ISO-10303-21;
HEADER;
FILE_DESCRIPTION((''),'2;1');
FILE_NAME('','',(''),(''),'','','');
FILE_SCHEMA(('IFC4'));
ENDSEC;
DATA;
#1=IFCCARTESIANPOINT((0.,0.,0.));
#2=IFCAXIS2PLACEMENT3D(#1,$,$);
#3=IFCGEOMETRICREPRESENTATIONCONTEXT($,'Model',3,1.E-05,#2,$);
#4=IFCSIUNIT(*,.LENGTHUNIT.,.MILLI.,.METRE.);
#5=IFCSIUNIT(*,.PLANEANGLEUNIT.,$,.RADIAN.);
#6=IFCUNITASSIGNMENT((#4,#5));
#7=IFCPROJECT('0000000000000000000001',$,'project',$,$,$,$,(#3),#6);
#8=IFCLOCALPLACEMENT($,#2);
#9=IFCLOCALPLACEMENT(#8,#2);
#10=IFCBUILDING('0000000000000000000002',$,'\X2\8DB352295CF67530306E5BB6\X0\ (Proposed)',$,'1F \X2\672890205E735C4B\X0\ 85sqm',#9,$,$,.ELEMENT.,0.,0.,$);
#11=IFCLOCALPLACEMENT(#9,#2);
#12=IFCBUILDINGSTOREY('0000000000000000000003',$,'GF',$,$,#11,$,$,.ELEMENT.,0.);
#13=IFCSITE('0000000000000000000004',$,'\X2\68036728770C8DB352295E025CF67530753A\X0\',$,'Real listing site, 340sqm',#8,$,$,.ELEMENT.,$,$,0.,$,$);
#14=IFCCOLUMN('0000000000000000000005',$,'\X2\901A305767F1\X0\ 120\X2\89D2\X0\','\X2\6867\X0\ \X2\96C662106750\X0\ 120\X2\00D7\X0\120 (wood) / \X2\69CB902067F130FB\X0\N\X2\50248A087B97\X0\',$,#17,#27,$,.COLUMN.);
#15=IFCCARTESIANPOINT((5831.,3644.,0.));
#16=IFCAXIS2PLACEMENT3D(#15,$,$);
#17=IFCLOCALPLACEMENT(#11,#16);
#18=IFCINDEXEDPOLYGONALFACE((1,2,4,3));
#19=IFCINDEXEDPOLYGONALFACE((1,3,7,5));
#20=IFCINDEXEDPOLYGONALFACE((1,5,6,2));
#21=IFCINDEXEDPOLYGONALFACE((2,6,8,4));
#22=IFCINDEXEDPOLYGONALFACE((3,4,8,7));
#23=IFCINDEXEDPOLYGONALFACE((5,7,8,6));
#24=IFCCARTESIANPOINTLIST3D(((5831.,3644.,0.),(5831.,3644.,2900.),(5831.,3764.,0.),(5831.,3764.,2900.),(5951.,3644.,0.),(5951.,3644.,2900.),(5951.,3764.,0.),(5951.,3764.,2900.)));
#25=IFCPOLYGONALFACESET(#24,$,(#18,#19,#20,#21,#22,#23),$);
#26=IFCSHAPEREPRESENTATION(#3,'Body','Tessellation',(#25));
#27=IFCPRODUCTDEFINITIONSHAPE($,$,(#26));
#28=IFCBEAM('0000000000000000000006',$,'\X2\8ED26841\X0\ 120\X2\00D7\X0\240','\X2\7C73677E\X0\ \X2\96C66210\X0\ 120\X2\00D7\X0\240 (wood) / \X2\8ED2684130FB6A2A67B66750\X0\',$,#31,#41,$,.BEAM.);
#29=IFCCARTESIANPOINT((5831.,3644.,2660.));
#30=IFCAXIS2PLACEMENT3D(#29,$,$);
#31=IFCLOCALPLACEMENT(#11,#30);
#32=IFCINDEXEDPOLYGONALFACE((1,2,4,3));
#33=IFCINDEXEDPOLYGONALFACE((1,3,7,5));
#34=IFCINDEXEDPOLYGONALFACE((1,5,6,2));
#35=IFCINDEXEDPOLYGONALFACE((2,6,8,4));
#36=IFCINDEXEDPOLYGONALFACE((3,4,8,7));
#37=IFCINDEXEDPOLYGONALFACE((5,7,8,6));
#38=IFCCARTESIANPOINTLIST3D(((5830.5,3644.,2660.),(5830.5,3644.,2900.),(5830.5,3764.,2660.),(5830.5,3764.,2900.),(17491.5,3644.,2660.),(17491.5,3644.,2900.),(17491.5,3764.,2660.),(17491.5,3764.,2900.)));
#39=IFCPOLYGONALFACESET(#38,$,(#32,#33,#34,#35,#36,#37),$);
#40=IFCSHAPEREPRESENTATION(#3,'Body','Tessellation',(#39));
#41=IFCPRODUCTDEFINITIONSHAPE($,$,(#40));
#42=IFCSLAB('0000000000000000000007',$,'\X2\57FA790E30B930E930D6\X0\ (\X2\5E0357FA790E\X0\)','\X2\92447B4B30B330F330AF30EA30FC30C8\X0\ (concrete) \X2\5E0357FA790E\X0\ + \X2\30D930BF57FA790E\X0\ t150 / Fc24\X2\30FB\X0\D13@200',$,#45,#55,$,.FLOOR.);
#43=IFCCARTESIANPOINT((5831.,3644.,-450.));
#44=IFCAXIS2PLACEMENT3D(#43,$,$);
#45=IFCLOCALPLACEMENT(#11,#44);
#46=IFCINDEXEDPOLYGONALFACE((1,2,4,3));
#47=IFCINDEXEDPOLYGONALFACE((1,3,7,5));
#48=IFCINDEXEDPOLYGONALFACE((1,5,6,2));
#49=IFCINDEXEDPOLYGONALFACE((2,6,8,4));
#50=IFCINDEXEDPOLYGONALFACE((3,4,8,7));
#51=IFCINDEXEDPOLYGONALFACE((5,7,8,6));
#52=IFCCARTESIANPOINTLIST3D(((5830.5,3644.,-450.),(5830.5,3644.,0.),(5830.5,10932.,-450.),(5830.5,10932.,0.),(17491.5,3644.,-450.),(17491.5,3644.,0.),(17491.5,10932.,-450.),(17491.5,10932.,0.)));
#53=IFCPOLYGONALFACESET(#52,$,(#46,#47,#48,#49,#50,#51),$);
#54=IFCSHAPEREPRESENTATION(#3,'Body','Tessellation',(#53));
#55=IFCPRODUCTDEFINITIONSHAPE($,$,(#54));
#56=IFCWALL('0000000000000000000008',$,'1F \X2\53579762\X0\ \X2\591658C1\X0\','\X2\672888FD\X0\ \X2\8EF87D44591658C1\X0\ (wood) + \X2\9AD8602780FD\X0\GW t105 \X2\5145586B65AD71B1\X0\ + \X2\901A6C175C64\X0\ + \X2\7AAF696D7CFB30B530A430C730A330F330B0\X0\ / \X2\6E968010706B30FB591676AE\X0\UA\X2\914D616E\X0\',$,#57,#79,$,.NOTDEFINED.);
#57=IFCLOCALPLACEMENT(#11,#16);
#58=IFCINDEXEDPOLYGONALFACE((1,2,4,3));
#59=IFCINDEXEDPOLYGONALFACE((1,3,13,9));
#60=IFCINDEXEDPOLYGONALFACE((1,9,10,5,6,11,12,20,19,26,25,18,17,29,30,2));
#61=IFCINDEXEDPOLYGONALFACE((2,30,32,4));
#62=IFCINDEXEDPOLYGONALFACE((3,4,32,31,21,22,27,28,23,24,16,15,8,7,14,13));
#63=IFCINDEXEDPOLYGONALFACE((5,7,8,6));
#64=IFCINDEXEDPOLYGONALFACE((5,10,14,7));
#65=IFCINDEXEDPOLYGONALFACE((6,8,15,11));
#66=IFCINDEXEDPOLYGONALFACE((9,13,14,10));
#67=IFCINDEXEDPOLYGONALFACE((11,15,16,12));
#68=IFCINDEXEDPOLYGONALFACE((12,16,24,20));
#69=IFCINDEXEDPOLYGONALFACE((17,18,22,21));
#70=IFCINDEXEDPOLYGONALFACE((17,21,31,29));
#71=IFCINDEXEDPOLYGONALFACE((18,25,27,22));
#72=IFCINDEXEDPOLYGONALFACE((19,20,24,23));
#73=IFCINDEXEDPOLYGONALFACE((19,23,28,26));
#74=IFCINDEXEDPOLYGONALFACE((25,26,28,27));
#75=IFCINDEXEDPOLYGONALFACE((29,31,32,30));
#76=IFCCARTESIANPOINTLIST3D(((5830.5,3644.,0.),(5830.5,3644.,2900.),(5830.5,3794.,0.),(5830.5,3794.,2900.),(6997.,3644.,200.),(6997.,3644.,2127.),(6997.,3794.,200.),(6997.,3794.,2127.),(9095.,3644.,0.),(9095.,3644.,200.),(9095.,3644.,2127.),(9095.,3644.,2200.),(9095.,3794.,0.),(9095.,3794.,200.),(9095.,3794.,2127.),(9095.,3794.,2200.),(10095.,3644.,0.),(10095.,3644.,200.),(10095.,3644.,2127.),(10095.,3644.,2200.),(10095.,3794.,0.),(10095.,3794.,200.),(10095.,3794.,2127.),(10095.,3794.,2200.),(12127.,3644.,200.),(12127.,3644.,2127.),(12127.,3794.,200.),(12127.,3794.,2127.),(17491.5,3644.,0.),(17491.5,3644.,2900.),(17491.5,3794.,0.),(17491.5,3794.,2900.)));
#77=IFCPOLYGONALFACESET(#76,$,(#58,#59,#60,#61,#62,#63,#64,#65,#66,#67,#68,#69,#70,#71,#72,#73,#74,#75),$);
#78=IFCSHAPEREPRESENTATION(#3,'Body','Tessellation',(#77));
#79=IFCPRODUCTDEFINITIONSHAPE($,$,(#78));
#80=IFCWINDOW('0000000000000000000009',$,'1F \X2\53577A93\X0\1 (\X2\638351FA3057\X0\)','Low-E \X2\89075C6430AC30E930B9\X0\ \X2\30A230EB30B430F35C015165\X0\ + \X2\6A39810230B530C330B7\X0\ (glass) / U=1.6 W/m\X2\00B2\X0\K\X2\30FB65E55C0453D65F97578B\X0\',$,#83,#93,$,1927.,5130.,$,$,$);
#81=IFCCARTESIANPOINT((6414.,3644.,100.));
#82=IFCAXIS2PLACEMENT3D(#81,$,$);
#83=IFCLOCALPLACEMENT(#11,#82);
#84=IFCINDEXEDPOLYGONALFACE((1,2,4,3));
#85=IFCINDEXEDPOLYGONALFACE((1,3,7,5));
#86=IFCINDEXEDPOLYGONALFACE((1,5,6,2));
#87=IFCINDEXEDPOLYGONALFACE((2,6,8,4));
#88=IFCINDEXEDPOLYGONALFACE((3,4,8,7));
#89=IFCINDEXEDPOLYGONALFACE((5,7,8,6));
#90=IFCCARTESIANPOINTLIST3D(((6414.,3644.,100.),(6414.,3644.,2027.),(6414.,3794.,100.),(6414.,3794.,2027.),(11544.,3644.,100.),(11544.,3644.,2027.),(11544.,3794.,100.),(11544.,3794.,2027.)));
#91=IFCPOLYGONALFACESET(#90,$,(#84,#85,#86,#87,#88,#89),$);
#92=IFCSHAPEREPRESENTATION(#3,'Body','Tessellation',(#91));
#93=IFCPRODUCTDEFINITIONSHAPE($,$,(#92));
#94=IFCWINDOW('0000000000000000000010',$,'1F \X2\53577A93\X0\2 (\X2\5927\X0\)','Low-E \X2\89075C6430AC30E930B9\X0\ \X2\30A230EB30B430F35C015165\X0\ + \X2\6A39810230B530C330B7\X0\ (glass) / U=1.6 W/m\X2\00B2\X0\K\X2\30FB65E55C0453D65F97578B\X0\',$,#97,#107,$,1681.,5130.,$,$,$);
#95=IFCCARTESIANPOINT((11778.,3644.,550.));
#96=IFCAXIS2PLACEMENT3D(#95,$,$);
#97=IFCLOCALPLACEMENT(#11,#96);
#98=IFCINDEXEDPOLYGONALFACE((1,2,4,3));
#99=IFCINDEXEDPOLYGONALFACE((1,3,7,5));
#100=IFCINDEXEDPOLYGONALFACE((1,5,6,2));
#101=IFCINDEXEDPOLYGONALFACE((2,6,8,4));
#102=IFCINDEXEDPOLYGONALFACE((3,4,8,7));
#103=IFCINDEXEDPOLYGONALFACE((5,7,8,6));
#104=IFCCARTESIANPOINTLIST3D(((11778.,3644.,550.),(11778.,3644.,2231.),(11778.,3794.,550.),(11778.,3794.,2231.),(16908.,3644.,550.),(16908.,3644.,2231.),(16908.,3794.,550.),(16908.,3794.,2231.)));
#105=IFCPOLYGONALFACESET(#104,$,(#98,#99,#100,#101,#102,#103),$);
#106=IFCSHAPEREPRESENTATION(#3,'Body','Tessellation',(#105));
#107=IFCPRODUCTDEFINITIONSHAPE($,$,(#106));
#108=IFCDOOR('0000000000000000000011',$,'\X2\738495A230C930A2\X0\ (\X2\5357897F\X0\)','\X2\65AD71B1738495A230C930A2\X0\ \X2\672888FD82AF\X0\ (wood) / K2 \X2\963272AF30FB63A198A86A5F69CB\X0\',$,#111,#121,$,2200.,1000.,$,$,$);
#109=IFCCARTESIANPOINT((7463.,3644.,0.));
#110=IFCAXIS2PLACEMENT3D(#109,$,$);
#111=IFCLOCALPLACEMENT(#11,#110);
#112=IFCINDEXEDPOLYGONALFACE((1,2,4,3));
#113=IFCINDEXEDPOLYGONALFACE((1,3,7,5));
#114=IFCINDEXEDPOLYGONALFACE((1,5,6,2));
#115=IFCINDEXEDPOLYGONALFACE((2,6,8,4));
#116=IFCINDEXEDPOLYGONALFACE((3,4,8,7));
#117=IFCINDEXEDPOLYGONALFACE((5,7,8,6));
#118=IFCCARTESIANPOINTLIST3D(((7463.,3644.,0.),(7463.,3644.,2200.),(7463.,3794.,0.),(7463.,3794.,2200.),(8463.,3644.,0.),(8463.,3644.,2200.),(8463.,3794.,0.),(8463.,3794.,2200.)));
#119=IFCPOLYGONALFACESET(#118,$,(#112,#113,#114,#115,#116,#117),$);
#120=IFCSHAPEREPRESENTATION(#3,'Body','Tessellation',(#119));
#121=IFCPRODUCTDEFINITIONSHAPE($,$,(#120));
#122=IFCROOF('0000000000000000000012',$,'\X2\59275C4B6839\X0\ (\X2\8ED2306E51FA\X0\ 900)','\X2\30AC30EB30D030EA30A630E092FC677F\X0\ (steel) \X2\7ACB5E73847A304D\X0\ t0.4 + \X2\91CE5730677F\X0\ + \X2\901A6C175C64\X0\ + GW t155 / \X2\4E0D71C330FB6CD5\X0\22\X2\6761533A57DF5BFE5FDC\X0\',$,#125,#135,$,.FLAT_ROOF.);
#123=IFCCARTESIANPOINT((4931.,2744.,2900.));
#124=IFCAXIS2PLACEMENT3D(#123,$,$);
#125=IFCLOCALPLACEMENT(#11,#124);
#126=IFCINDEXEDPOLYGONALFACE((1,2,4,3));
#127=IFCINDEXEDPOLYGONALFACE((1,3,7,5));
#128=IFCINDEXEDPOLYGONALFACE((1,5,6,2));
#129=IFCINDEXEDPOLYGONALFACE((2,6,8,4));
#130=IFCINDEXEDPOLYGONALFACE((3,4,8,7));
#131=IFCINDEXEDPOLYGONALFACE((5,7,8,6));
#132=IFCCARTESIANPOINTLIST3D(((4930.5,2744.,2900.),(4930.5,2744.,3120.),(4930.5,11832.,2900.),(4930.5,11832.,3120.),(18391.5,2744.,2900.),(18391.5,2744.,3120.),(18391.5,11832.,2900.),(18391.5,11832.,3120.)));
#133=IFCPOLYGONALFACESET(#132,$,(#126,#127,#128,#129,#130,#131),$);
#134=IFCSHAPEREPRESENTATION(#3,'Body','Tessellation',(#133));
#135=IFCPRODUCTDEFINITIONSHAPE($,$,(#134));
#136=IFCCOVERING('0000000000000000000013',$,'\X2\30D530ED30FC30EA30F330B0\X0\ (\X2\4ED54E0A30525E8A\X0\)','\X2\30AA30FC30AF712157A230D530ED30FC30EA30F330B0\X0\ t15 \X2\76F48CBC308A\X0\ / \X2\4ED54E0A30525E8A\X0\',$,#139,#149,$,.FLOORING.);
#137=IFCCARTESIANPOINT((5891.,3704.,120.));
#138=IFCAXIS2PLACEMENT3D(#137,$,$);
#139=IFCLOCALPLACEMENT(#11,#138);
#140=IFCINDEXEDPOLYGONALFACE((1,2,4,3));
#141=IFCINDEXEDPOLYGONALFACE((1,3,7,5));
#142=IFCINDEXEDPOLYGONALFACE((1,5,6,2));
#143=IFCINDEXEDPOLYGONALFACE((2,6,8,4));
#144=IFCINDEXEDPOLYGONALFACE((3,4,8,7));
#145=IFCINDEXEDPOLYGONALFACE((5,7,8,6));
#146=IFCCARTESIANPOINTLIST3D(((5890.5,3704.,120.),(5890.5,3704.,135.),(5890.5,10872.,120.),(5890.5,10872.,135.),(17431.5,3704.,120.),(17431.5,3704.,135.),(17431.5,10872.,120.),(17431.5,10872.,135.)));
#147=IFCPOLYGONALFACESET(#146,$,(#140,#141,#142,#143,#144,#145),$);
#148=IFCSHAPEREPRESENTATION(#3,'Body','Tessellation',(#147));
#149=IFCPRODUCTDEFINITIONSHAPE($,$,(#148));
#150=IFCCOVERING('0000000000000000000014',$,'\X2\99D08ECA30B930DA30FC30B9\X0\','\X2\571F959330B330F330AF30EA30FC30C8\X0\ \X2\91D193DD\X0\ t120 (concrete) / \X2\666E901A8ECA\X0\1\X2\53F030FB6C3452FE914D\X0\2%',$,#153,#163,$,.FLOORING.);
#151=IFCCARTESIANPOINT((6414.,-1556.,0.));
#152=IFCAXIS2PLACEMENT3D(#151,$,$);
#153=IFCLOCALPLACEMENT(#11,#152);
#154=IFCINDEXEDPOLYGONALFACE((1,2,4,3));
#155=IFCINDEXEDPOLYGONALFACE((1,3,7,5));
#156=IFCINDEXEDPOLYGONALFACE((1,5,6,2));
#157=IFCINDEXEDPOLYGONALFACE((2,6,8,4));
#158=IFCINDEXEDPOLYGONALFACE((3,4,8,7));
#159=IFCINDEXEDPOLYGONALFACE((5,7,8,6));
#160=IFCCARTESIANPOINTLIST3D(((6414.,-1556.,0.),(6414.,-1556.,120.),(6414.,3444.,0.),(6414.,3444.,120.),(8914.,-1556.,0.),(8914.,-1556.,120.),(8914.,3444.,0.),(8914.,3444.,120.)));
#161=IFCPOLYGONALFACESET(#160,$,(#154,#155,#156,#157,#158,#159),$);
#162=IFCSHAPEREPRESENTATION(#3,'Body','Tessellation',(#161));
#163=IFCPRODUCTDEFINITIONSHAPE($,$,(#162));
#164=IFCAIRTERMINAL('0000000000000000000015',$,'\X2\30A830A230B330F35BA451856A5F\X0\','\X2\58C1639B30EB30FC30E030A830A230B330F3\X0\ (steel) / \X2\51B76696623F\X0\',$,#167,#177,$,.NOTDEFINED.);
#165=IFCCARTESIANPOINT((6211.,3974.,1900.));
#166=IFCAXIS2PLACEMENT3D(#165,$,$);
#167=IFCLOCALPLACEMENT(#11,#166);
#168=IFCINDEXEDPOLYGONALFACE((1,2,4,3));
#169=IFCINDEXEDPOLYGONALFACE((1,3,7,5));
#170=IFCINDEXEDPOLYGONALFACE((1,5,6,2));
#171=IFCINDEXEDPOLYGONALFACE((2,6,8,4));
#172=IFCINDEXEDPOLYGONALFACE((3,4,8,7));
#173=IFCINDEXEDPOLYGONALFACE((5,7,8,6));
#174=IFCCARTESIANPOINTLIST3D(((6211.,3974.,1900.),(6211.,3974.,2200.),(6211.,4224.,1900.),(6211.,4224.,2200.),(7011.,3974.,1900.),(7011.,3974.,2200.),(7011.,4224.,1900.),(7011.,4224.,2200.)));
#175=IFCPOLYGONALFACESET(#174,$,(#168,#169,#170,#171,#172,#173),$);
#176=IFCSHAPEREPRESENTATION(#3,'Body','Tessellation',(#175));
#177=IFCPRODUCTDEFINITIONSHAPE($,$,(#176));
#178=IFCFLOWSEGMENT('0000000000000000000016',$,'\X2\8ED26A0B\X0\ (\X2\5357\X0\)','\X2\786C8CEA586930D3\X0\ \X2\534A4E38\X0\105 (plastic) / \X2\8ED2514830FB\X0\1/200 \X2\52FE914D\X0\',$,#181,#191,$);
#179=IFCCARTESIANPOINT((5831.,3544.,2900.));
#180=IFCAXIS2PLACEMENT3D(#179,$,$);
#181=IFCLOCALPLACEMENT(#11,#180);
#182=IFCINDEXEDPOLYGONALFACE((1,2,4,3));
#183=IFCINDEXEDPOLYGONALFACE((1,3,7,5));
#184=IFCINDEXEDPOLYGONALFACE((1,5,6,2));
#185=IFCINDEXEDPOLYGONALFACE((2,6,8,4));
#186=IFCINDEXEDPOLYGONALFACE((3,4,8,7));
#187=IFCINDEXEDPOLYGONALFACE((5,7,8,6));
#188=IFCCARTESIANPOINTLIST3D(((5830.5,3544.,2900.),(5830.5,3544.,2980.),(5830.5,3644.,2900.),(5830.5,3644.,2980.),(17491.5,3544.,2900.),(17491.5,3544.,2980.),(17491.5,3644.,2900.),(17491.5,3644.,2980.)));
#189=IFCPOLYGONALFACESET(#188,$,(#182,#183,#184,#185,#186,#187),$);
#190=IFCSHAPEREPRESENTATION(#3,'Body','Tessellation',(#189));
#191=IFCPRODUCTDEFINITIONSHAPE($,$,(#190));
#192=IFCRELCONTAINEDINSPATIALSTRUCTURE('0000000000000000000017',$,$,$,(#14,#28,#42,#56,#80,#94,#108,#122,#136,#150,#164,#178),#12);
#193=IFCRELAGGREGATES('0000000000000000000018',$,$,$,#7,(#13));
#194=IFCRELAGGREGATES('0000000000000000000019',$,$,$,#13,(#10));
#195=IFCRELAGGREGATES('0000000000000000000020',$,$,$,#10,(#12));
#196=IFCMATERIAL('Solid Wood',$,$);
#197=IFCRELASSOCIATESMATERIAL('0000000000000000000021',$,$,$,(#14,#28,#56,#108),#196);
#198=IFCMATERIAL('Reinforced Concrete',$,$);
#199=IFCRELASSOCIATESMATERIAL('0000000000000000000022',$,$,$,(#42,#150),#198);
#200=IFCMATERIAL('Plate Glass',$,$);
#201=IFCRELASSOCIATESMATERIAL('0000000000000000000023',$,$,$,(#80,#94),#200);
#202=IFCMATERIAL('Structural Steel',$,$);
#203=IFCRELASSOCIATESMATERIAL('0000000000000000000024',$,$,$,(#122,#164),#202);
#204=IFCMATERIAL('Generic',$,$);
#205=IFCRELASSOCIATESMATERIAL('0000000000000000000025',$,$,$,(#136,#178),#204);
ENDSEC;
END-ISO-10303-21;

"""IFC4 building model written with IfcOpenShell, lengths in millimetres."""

from ifc_helpers import new_model, si_unit, frame, frame_2d, origin, place, context, project, spatial, rectangle, extrude, material, element, fill, save


model = new_model("IFC4")

# Units and contexts
model_context = context("Model", 3, precision=1e-05, world=origin())
ifc_project = project(units=[si_unit("LENGTHUNIT", "METRE", prefix="MILLI"), si_unit("PLANEANGLEUNIT", "RADIAN")], contexts=[model_context])

# Site, building, storey
site_placement = place(None, origin())
site = spatial("IfcSite", under=ifc_project, at=site_placement, Name="栃木県足利市島田町", ObjectType="Real listing site, 340sqm", CompositionType="ELEMENT", RefElevation=0.0)
building_placement = place(site_placement, origin())
building = spatial("IfcBuilding", under=site, at=building_placement, Name="足利島田の家 (Proposed)", ObjectType="1F 木造平屋 85sqm", CompositionType="ELEMENT", ElevationOfRefHeight=0.0, ElevationOfTerrain=0.0)
storey_placement = place(building_placement, origin())
storey = spatial("IfcBuildingStorey", under=building, at=storey_placement, Name="GF", CompositionType="ELEMENT", Elevation=0.0)

# Column
ifc_material_1 = material(Name="Solid Wood")
column_1_placement = place(storey_placement, frame((5831.0, 3644.0, 0.0)))
element("IfcColumn", 1, at=column_1_placement, inside=storey, material=ifc_material_1, Name="通し柱 120角", Description="桧 集成材 120×120 (wood) / 構造柱・N値計算", PredefinedType="COLUMN", context=model_context, shape_type="SweptSolid", body=[
    extrude(rectangle(XDim=120.0, YDim=120.0, at=frame_2d((60.0, 60.0))), frame((5831.0, 3644.0, 0.0)), (0.0, 0.0, 1.0), 2900.0),
])

# Beam
beam_1_placement = place(storey_placement, frame((5831.0, 3644.0, 2660.0)))
element("IfcBeam", 2, at=beam_1_placement, inside=storey, material=ifc_material_1, Name="軒桁 120×240", Description="米松 集成 120×240 (wood) / 軒桁・横架材", PredefinedType="BEAM", context=model_context, shape_type="SweptSolid", body=[
    extrude(rectangle(XDim=11661.0, YDim=120.0, at=frame_2d((5830.0, 60.0))), frame((5831.0, 3644.0, 2660.0)), (0.0, 0.0, 1.0), 240.0),
])

# Slab
ifc_material_2 = material(Name="Reinforced Concrete")
slab_1_placement = place(storey_placement, frame((5831.0, 3644.0, -450.0)))
element("IfcSlab", 3, at=slab_1_placement, inside=storey, material=ifc_material_2, Name="基礎スラブ (布基礎)", Description="鉄筋コンクリート (concrete) 布基礎 + ベタ基礎 t150 / Fc24・D13@200", PredefinedType="FLOOR", context=model_context, shape_type="SweptSolid", body=[
    extrude(rectangle(XDim=11661.0, YDim=7288.0, at=frame_2d((5830.0, 3644.0))), frame((5831.0, 3644.0, -450.0)), (0.0, 0.0, 1.0), 450.0),
])

# Wall, openings, windows, door
wall_1_placement = place(storey_placement, frame((5831.0, 3644.0, 0.0)))
wall_1 = element("IfcWall", 4, at=wall_1_placement, inside=storey, material=ifc_material_1, Name="1F 南面 外壁", Description="木製 軸組外壁 (wood) + 高性能GW t105 充填断熱 + 通気層 + 窯業系サイディング / 準耐火・外皮UA配慮", PredefinedType="NOTDEFINED", context=model_context, shape_type="SweptSolid", body=[
    extrude(rectangle(XDim=11661.0, YDim=150.0, at=frame_2d((5830.0, 75.0))), frame((5831.0, 3644.0, 0.0)), (0.0, 0.0, 1.0), 2900.0),
])
opening_1_placement = place(storey_placement, frame((6414.0, 3644.0, 100.0)))
opening_1 = element("IfcOpeningElement", 5, at=opening_1_placement, cuts=wall_1, PredefinedType="NOTDEFINED", context=model_context, shape_type="SweptSolid", body=[
    extrude(rectangle(XDim=5130.0, YDim=150.0, at=frame_2d((2565.0, 75.0))), frame((6414.0, 3644.0, 100.0)), (0.0, 0.0, 1.0), 1927.0),
])
opening_2_placement = place(storey_placement, frame((11778.0, 3644.0, 550.0)))
opening_2 = element("IfcOpeningElement", 6, at=opening_2_placement, cuts=wall_1, PredefinedType="NOTDEFINED", context=model_context, shape_type="SweptSolid", body=[
    extrude(rectangle(XDim=5130.0, YDim=150.0, at=frame_2d((2565.0, 75.0))), frame((11778.0, 3644.0, 550.0)), (0.0, 0.0, 1.0), 1681.0),
])
opening_3_placement = place(storey_placement, frame((7463.0, 3644.0, 0.0)))
opening_3 = element("IfcOpeningElement", 7, at=opening_3_placement, cuts=wall_1, PredefinedType="NOTDEFINED", context=model_context, shape_type="SweptSolid", body=[
    extrude(rectangle(XDim=1000.0, YDim=150.0, at=frame_2d((500.0, 75.0))), frame((7463.0, 3644.0, 0.0)), (0.0, 0.0, 1.0), 2200.0),
])
ifc_material_3 = material(Name="Plate Glass")
window_1_placement = place(storey_placement, frame((6414.0, 3644.0, 100.0)))
window_1 = element("IfcWindow", 8, at=window_1_placement, inside=storey, material=ifc_material_3, Name="1F 南窓1 (掃出し)", Description="Low-E 複層ガラス アルゴン封入 + 樹脂サッシ (glass) / U=1.6 W/m²K・日射取得型", OverallHeight=1927.0, OverallWidth=5130.0, context=model_context, shape_type="SweptSolid", body=[
    extrude(rectangle(XDim=5130.0, YDim=150.0, at=frame_2d((2565.0, 75.0))), frame((6414.0, 3644.0, 100.0)), (0.0, 0.0, 1.0), 1927.0),
])
fill(opening_1, window_1)
window_2_placement = place(storey_placement, frame((11778.0, 3644.0, 550.0)))
window_2 = element("IfcWindow", 9, at=window_2_placement, inside=storey, material=ifc_material_3, Name="1F 南窓2 (大)", Description="Low-E 複層ガラス アルゴン封入 + 樹脂サッシ (glass) / U=1.6 W/m²K・日射取得型", OverallHeight=1681.0, OverallWidth=5130.0, context=model_context, shape_type="SweptSolid", body=[
    extrude(rectangle(XDim=5130.0, YDim=150.0, at=frame_2d((2565.0, 75.0))), frame((11778.0, 3644.0, 550.0)), (0.0, 0.0, 1.0), 1681.0),
])
fill(opening_2, window_2)
door_placement = place(storey_placement, frame((7463.0, 3644.0, 0.0)))
door = element("IfcDoor", 10, at=door_placement, inside=storey, material=ifc_material_1, Name="玄関ドア (南西)", Description="断熱玄関ドア 木製芯 (wood) / K2 防犯・採風機構", OverallHeight=2200.0, OverallWidth=1000.0, context=model_context, shape_type="SweptSolid", body=[
    extrude(rectangle(XDim=1000.0, YDim=150.0, at=frame_2d((500.0, 75.0))), frame((7463.0, 3644.0, 0.0)), (0.0, 0.0, 1.0), 2200.0),
])
fill(opening_3, door)

# Roof
ifc_material_4 = material(Name="Structural Steel")
roof_placement = place(storey_placement, frame((4931.0, 2744.0, 2900.0)))
element("IfcRoof", 11, at=roof_placement, inside=storey, material=ifc_material_4, Name="大屋根 (軒の出 900)", Description="ガルバリウム鋼板 (steel) 立平葺き t0.4 + 野地板 + 通気層 + GW t155 / 不燃・法22条区域対応", PredefinedType="FLAT_ROOF", context=model_context, shape_type="SweptSolid", body=[
    extrude(rectangle(XDim=13461.0, YDim=9088.0, at=frame_2d((6730.0, 4544.0))), frame((4931.0, 2744.0, 2900.0)), (0.0, 0.0, 1.0), 220.0),
])

# Coverings
ifc_material_5 = material(Name="Generic")
covering_1_placement = place(storey_placement, frame((5891.0, 3704.0, 120.0)))
element("IfcCovering", 12, at=covering_1_placement, inside=storey, material=ifc_material_5, Name="フローリング (仕上げ床)", Description="オーク無垢フローリング t15 直貼り / 仕上げ床", PredefinedType="FLOORING", context=model_context, shape_type="SweptSolid", body=[
    extrude(rectangle(XDim=11541.0, YDim=7168.0, at=frame_2d((5770.0, 3584.0))), frame((5891.0, 3704.0, 120.0)), (0.0, 0.0, 1.0), 15.0),
])
covering_2_placement = place(storey_placement, frame((6414.0, -1556.0, 0.0)))
element("IfcCovering", 13, at=covering_2_placement, inside=storey, material=ifc_material_2, Name="駐車スペース", Description="土間コンクリート 金鏝 t120 (concrete) / 普通車1台・水勾配2%", PredefinedType="FLOORING", context=model_context, shape_type="SweptSolid", body=[
    extrude(rectangle(XDim=2500.0, YDim=5000.0, at=frame_2d((1250.0, 2500.0))), frame((6414.0, -1556.0, 0.0)), (0.0, 0.0, 1.0), 120.0),
])

# Air terminal
air_terminal_placement = place(storey_placement, frame((6211.0, 3974.0, 1900.0)))
element("IfcAirTerminal", 14, at=air_terminal_placement, inside=storey, material=ifc_material_4, Name="エアコン室内機", Description="壁掛ルームエアコン (steel) / 冷暖房", PredefinedType="NOTDEFINED", context=model_context, shape_type="SweptSolid", body=[
    extrude(rectangle(XDim=800.0, YDim=250.0, at=frame_2d((400.0, 125.0))), frame((6211.0, 3974.0, 1900.0)), (0.0, 0.0, 1.0), 300.0),
])

# Flow segment
flow_segment_1_placement = place(storey_placement, frame((5831.0, 3544.0, 2900.0)))
element("IfcFlowSegment", 15, at=flow_segment_1_placement, inside=storey, material=ifc_material_5, Name="軒樋 (南)", Description="硬質塩ビ 半丸105 (plastic) / 軒先・1/200 勾配", context=model_context, shape_type="SweptSolid", body=[
    extrude(rectangle(XDim=11661.0, YDim=100.0, at=frame_2d((5830.0, 50.0))), frame((5831.0, 3544.0, 2900.0)), (0.0, 0.0, 1.0), 80.0),
])

save(model, "model.ifc")
